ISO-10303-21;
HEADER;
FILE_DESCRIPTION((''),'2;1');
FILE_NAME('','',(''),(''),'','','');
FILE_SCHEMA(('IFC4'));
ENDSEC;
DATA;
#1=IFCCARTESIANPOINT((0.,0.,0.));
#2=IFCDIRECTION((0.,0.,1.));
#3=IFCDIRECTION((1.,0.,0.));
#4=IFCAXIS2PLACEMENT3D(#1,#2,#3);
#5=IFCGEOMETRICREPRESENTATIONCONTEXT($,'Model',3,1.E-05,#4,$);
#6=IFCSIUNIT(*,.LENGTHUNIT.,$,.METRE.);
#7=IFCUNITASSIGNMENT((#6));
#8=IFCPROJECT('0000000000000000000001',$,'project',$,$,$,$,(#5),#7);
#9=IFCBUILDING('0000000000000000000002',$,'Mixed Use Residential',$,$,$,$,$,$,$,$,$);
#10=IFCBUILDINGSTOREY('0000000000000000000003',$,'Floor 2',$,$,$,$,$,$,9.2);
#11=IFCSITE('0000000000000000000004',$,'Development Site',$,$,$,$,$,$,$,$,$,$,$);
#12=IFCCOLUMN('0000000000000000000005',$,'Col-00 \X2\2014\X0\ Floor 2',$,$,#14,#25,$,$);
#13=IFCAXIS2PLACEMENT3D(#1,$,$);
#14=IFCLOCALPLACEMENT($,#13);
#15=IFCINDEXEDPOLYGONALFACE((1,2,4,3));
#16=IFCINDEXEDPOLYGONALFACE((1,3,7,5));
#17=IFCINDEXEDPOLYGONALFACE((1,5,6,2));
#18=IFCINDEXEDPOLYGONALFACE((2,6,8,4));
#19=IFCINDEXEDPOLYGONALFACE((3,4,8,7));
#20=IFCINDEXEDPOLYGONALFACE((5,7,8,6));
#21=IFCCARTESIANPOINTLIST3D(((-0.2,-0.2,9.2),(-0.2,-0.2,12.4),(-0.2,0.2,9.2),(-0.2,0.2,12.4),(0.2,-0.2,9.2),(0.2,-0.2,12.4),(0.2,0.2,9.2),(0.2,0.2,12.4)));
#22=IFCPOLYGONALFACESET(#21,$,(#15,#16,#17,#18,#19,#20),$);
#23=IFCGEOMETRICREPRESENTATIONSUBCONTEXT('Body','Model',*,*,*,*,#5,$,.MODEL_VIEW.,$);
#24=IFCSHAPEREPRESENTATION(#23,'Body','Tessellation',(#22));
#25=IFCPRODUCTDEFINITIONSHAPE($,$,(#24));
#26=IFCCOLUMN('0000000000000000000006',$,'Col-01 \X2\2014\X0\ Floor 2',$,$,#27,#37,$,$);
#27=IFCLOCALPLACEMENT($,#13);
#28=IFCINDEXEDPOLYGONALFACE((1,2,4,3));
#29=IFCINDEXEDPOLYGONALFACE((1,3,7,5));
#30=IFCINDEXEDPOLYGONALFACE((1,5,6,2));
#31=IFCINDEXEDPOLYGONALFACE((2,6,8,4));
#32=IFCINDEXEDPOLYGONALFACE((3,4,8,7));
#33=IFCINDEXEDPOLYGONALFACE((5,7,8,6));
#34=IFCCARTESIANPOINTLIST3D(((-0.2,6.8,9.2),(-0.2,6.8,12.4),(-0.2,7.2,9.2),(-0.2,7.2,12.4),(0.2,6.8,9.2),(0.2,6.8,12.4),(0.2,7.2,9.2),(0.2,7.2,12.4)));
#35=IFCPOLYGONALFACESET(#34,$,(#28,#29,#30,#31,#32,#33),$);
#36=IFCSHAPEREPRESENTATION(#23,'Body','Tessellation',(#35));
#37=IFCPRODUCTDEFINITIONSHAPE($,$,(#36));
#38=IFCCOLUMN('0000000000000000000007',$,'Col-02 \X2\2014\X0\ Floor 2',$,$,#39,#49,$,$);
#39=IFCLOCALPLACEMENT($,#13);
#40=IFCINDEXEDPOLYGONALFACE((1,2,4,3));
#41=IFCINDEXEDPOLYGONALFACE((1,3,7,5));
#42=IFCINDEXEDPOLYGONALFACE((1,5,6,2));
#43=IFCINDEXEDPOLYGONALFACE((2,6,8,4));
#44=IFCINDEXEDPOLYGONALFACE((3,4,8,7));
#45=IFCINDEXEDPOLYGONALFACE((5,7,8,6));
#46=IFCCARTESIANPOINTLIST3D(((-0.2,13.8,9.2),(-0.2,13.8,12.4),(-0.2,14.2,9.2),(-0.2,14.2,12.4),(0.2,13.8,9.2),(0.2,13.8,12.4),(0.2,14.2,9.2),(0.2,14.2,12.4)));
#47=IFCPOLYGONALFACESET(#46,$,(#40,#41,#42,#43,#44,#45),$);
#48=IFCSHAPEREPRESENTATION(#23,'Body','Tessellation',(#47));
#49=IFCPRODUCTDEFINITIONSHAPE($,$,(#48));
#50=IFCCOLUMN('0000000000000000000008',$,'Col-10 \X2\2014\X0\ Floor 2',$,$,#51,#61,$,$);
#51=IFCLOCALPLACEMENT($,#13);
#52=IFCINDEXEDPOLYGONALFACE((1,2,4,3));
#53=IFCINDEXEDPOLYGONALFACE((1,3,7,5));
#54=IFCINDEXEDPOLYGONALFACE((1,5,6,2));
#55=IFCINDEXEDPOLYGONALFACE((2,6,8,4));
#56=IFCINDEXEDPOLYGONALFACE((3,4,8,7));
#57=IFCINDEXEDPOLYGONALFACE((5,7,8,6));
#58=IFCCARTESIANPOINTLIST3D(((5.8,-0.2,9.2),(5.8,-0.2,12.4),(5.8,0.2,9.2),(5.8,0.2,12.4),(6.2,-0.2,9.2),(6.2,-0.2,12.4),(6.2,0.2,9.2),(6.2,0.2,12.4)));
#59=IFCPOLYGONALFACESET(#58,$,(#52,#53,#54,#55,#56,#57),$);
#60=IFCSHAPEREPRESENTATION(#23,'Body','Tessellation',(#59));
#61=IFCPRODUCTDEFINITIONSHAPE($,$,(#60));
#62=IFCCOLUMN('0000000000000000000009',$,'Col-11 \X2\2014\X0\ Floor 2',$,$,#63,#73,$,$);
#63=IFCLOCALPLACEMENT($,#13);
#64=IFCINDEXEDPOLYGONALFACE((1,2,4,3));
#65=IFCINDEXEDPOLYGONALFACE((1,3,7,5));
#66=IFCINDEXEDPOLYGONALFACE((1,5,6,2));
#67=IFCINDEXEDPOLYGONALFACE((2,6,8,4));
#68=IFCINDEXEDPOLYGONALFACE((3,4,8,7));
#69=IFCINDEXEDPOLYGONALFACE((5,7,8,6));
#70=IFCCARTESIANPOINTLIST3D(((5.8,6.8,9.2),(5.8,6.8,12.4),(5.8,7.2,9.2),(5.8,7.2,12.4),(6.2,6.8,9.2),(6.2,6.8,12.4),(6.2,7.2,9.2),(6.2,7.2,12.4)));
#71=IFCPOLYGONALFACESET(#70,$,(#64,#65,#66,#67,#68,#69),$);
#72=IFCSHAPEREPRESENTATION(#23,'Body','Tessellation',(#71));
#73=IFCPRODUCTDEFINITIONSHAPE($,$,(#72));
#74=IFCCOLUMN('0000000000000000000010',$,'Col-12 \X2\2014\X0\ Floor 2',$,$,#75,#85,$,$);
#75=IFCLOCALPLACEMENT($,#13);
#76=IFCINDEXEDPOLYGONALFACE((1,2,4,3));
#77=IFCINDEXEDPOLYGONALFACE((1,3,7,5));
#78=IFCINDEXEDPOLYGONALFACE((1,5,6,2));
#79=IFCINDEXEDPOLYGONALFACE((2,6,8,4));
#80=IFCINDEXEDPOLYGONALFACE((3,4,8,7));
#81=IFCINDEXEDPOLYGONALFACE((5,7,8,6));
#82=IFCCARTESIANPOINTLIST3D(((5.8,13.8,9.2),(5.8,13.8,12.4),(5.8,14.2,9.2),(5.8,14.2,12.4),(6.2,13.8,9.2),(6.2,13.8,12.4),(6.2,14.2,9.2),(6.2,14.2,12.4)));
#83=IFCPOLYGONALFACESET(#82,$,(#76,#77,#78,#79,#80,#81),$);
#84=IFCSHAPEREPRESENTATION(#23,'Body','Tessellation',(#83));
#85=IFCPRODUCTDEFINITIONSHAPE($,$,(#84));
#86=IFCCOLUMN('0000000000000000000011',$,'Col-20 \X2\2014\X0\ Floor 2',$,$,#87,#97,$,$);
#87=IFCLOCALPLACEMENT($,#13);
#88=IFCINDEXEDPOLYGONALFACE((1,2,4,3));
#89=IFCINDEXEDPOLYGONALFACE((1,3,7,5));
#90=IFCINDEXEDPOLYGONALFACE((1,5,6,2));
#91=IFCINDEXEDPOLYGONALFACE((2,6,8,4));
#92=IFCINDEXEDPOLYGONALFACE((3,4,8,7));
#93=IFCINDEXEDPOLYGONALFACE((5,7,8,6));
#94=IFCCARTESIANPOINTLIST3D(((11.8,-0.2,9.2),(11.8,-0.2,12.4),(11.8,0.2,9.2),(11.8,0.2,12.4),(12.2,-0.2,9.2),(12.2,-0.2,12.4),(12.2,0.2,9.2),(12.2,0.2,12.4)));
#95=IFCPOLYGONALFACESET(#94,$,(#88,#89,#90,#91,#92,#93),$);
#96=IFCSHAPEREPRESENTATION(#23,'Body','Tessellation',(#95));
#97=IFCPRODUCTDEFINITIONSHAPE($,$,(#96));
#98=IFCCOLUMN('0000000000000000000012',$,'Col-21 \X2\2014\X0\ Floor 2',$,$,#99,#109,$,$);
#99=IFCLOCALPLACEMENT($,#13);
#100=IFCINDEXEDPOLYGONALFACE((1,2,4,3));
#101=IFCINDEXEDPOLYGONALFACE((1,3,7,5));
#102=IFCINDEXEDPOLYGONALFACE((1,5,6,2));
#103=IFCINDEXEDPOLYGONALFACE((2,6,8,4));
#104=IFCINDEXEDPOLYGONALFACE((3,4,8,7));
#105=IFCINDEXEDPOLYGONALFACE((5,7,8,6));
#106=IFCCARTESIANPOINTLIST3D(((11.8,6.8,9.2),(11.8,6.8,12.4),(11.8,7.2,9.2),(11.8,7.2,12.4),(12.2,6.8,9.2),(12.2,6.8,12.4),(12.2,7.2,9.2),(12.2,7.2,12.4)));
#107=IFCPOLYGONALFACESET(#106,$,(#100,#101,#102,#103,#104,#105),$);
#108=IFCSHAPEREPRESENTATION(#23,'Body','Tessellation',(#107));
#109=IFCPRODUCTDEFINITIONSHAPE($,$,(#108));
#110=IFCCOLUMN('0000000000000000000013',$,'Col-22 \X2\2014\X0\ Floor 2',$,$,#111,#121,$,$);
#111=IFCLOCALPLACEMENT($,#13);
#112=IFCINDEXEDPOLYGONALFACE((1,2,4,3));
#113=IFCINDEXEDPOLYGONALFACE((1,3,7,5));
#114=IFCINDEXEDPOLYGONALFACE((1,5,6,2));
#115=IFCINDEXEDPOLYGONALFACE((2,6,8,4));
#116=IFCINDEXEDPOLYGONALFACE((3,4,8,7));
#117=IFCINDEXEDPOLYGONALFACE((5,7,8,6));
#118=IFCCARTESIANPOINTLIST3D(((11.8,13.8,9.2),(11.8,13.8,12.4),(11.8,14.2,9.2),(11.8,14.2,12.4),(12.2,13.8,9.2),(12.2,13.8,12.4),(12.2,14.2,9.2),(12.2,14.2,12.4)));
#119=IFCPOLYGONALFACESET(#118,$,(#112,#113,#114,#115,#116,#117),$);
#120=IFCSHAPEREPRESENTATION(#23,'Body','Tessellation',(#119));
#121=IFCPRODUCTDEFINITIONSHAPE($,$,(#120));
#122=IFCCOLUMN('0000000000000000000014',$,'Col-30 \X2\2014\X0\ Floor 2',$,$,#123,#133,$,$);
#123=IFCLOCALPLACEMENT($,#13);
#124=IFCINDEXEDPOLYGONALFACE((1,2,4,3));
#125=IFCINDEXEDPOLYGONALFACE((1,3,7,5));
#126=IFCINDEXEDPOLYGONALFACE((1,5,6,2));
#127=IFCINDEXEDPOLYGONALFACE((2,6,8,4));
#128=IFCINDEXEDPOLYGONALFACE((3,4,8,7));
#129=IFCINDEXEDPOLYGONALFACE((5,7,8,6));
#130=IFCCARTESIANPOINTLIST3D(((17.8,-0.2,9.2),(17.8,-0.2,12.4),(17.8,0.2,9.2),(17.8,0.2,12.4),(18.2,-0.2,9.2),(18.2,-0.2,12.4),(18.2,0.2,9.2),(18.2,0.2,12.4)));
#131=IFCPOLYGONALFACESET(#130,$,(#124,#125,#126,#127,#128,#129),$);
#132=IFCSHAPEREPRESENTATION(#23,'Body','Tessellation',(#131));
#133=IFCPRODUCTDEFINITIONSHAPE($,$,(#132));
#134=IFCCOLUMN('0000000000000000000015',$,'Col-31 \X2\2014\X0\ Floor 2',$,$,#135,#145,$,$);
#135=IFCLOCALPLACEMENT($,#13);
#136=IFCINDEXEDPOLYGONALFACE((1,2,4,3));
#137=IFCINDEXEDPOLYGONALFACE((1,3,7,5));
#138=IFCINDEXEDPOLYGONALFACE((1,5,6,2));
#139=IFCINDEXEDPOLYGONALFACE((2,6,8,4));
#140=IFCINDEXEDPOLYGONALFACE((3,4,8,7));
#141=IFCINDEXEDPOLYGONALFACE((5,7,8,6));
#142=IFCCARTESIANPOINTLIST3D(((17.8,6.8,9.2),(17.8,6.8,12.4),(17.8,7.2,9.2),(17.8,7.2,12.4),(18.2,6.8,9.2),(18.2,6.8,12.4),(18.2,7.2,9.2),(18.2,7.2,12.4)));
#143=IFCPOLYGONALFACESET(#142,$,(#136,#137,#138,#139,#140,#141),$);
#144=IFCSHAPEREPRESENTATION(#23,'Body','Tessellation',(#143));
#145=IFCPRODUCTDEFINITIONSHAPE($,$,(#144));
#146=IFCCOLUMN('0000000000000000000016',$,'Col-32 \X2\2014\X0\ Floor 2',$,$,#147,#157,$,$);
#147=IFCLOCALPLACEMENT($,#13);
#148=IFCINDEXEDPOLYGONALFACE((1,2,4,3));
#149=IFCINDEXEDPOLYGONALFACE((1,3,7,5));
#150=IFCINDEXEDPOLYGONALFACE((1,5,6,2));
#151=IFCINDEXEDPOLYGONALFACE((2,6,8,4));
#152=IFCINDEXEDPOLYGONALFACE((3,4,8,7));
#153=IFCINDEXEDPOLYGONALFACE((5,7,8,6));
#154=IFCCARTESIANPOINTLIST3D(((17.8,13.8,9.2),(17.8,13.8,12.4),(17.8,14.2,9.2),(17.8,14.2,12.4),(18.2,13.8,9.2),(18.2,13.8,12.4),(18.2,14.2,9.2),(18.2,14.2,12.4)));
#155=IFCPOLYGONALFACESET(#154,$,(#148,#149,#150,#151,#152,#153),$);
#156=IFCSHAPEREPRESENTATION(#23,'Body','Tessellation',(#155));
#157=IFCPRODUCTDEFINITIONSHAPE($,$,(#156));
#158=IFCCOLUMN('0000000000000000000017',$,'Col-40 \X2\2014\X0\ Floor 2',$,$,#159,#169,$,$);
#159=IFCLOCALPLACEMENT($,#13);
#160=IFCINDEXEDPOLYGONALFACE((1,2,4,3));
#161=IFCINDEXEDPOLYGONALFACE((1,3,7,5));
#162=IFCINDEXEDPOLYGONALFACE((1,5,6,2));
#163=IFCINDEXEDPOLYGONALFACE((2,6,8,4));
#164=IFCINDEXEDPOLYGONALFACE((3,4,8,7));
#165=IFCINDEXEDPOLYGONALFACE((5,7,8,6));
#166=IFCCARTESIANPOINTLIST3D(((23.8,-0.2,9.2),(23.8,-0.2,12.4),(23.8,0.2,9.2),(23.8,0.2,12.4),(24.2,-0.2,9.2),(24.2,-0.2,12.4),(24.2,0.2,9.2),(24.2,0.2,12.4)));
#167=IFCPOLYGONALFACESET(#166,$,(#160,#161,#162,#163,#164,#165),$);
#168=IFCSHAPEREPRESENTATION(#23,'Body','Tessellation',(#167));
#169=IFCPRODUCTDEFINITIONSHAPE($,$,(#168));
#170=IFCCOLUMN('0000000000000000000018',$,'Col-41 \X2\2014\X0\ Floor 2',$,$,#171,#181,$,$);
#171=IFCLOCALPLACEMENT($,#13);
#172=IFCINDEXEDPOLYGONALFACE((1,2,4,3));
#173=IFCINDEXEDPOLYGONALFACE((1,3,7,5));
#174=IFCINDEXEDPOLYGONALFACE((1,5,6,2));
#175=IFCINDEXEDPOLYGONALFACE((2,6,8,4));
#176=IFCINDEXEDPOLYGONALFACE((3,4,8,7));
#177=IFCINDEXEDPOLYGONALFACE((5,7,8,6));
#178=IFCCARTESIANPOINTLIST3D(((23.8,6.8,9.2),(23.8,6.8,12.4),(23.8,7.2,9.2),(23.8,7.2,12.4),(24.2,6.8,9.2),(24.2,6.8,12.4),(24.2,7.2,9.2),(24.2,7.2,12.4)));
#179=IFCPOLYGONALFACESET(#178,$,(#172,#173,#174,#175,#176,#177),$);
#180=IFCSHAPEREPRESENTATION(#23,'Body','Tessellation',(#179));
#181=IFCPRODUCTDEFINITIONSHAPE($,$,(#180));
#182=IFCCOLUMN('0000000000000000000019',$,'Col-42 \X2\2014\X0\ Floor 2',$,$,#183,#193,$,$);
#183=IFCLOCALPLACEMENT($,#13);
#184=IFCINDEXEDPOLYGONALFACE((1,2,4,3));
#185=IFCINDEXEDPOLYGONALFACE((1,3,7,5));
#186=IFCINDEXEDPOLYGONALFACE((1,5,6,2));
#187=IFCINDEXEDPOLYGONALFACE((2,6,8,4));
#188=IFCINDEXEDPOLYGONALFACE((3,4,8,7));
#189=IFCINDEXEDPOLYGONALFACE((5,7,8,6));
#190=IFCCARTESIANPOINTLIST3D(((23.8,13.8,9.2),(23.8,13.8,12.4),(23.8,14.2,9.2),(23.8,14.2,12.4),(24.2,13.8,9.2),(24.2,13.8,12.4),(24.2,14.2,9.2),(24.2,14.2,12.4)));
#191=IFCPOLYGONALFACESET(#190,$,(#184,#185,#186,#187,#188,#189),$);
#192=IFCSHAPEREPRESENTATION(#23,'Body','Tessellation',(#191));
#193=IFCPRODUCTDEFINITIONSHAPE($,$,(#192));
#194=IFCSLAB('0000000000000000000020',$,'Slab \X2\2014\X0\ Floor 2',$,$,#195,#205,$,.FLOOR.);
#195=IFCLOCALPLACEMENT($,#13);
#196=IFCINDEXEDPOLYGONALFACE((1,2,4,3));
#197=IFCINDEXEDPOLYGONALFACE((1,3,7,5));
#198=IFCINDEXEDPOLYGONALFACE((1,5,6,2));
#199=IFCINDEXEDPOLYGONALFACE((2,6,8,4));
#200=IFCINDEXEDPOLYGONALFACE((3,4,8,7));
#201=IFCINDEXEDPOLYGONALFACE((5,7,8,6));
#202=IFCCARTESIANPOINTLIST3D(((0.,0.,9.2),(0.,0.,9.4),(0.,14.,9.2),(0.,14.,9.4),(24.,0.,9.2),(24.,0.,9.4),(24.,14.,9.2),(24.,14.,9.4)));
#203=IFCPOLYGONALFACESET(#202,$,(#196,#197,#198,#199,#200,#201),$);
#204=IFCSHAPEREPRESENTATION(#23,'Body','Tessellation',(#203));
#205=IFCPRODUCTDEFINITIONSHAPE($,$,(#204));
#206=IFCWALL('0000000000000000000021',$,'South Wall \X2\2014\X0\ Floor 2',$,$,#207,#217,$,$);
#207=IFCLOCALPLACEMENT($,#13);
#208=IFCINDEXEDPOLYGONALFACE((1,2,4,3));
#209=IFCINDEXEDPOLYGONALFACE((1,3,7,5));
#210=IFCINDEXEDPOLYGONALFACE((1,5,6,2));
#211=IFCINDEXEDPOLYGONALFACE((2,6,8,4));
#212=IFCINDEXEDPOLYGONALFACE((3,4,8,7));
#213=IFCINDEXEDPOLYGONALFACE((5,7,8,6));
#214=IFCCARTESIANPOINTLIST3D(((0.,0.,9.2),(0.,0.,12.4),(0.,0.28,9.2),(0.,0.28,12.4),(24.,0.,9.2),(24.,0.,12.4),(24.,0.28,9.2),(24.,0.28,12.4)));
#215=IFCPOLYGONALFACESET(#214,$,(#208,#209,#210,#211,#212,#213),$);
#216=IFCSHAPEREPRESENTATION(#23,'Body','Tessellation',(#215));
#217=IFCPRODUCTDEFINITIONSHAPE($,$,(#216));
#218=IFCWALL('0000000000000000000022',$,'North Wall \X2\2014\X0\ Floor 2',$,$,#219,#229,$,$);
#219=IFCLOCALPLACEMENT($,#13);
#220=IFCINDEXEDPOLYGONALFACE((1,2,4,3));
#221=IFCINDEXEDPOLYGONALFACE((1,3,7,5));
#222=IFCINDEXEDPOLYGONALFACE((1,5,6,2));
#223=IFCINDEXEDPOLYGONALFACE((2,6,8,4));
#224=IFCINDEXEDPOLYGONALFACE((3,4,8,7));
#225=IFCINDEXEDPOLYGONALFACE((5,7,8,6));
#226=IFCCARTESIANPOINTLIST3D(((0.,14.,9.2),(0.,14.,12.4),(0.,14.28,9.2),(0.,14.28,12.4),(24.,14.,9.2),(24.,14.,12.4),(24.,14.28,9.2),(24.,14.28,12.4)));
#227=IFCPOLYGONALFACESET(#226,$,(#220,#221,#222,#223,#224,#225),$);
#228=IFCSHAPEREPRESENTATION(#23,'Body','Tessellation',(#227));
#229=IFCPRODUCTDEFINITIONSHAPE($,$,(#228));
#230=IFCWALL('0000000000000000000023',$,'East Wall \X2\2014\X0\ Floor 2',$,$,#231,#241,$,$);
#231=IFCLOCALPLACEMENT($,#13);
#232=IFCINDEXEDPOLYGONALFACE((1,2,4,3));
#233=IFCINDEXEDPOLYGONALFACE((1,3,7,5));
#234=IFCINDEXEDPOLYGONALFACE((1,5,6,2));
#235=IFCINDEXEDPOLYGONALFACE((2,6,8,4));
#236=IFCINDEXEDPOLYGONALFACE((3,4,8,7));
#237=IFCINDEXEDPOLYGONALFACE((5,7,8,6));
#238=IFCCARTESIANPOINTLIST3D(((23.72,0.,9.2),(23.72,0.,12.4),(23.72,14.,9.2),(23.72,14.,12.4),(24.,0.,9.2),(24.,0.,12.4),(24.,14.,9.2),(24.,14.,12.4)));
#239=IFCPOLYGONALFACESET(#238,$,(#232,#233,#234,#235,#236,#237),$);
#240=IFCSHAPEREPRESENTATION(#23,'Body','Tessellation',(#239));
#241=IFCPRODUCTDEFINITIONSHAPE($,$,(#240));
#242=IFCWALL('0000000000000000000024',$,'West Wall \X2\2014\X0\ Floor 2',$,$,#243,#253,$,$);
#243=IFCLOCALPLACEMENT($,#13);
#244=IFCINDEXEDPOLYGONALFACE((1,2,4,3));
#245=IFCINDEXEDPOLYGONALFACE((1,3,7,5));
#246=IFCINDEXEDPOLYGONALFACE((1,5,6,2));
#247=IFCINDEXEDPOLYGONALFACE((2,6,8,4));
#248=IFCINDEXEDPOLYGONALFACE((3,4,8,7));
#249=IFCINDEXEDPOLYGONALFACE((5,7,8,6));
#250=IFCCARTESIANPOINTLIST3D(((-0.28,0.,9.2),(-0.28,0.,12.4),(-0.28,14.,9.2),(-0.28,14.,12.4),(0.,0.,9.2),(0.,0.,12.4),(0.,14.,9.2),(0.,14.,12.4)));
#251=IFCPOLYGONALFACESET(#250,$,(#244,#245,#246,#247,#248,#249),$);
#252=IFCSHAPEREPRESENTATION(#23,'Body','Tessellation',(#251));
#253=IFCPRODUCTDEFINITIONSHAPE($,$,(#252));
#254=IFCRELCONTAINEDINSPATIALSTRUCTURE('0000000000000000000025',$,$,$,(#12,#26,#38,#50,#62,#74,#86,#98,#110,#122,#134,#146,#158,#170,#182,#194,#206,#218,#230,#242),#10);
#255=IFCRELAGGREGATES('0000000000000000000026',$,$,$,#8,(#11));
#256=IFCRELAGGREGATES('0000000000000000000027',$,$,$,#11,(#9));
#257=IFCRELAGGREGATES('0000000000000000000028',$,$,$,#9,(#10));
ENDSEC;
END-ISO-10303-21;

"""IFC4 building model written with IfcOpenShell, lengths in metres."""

from ifc_helpers import new_model, si_unit, frame, origin_with_axes, place, context, subcontext, project, spatial, indexed_curve, rectangle, outline, extrude, element, save


model = new_model("IFC4")

# Units and contexts
model_context = context("Model", 3, precision=1e-05, world=origin_with_axes())
body_context = subcontext(model_context, "Body", "Model", "MODEL_VIEW")
ifc_project = project(units=[si_unit("LENGTHUNIT", "METRE")], contexts=[model_context])

# Site, building, storey
site = spatial("IfcSite", under=ifc_project, Name="Development Site")
building = spatial("IfcBuilding", under=site, Name="Mixed Use Residential")
storey = spatial("IfcBuildingStorey", under=building, Name="Floor 2", Elevation=9.2)

# Columns
for number, where, z_axis, x_axis, name in (
    (1, (0.0, 0.0, 9.2), (0.0, 0.0, 1.0), (1.0, 0.0, 0.0), "Col-00 — Floor 2"),
    (2, (0.0, 7.0, 9.2), (0.0, 0.0, 1.0), (1.0, 0.0, 0.0), "Col-01 — Floor 2"),
    (3, (0.0, 14.0, 9.2), (0.0, 0.0, 1.0), (1.0, 0.0, 0.0), "Col-02 — Floor 2"),
    (4, (6.0, 0.0, 9.2), (0.0, 0.0, 1.0), (1.0, 0.0, 0.0), "Col-10 — Floor 2"),
    (5, (6.0, 7.0, 9.2), (0.0, 0.0, 1.0), (1.0, 0.0, 0.0), "Col-11 — Floor 2"),
    (6, (6.0, 14.0, 9.2), (0.0, 0.0, 1.0), (1.0, 0.0, 0.0), "Col-12 — Floor 2"),
    (7, (12.0, 0.0, 9.2), (0.0, 0.0, 1.0), (1.0, 0.0, 0.0), "Col-20 — Floor 2"),
    (8, (12.0, 7.0, 9.2), (0.0, 0.0, 1.0), (1.0, 0.0, 0.0), "Col-21 — Floor 2"),
    (9, (12.0, 14.0, 9.2), (0.0, 0.0, 1.0), (1.0, 0.0, 0.0), "Col-22 — Floor 2"),
    (10, (18.0, 0.0, 9.2), (0.0, 0.0, 1.0), (1.0, 0.0, 0.0), "Col-30 — Floor 2"),
    (11, (18.0, 7.0, 9.2), (0.0, 0.0, 1.0), (1.0, 0.0, 0.0), "Col-31 — Floor 2"),
    (12, (18.0, 14.0, 9.2), (0.0, 0.0, 1.0), (1.0, 0.0, 0.0), "Col-32 — Floor 2"),
    (13, (24.0, 0.0, 9.2), (0.0, 0.0, 1.0), (1.0, 0.0, 0.0), "Col-40 — Floor 2"),
    (14, (24.0, 7.0, 9.2), (0.0, 0.0, 1.0), (1.0, 0.0, 0.0), "Col-41 — Floor 2"),
    (15, (24.0, 14.0, 9.2), (0.0, 0.0, 1.0), (1.0, 0.0, 0.0), "Col-42 — Floor 2"),
):
    element("IfcColumn", number, at=place(None, frame(where, z_axis=z_axis, x_axis=x_axis)), inside=storey, Name=name, context=body_context, shape_type="SweptSolid", body=[
        extrude(rectangle(XDim=0.4, YDim=0.4), origin_with_axes(), (0.0, 0.0, 1.0), 3.2),
    ])

# Slab
slab_placement = place(None, frame((0.0, 0.0, 9.2), z_axis=(0.0, 0.0, 1.0), x_axis=(1.0, 0.0, 0.0)))
element("IfcSlab", 16, at=slab_placement, inside=storey, Name="Slab — Floor 2", PredefinedType="FLOOR", context=body_context, shape_type="SweptSolid", body=[
    extrude(outline(indexed_curve([(0.0, 0.0), (24.0, 0.0), (24.0, 14.0), (0.0, 14.0), (0.0, 0.0)])), None, (0.0, 0.0, 1.0), 0.2),
])

# Walls
for number, where, z_axis, x_axis, name in (
    (17, (0.0, 0.0, 9.2), (0.0, 0.0, 1.0), (1.0, 0.0, 0.0), "South Wall — Floor 2"),
    (18, (0.0, 14.0, 9.2), (0.0, 0.0, 1.0), (1.0, 0.0, 0.0), "North Wall — Floor 2"),
):
    element("IfcWall", number, at=place(None, frame(where, z_axis=z_axis, x_axis=x_axis)), inside=storey, Name=name, context=body_context, shape_type="SweptSolid", body=[
        extrude(outline(indexed_curve([(0.0, 0.0), (0.0, 0.28), (24.0, 0.28), (24.0, 0.0), (0.0, 0.0)], self_intersect=False)), origin_with_axes(), (0.0, 0.0, 1.0), 3.2),
    ])
for number, where, z_axis, x_axis, name in (
    (19, (24.0, 0.0, 9.2), (0.0, 0.0, 1.0), (0.0, 1.0, 0.0), "East Wall — Floor 2"),
    (20, (0.0, 0.0, 9.2), (0.0, 0.0, 1.0), (0.0, 1.0, 0.0), "West Wall — Floor 2"),
):
    element("IfcWall", number, at=place(None, frame(where, z_axis=z_axis, x_axis=x_axis)), inside=storey, Name=name, context=body_context, shape_type="SweptSolid", body=[
        extrude(outline(indexed_curve([(0.0, 0.0), (0.0, 0.28), (14.0, 0.28), (14.0, 0.0), (0.0, 0.0)], self_intersect=False)), origin_with_axes(), (0.0, 0.0, 1.0), 3.2),
    ])

save(model, "model.ifc")
